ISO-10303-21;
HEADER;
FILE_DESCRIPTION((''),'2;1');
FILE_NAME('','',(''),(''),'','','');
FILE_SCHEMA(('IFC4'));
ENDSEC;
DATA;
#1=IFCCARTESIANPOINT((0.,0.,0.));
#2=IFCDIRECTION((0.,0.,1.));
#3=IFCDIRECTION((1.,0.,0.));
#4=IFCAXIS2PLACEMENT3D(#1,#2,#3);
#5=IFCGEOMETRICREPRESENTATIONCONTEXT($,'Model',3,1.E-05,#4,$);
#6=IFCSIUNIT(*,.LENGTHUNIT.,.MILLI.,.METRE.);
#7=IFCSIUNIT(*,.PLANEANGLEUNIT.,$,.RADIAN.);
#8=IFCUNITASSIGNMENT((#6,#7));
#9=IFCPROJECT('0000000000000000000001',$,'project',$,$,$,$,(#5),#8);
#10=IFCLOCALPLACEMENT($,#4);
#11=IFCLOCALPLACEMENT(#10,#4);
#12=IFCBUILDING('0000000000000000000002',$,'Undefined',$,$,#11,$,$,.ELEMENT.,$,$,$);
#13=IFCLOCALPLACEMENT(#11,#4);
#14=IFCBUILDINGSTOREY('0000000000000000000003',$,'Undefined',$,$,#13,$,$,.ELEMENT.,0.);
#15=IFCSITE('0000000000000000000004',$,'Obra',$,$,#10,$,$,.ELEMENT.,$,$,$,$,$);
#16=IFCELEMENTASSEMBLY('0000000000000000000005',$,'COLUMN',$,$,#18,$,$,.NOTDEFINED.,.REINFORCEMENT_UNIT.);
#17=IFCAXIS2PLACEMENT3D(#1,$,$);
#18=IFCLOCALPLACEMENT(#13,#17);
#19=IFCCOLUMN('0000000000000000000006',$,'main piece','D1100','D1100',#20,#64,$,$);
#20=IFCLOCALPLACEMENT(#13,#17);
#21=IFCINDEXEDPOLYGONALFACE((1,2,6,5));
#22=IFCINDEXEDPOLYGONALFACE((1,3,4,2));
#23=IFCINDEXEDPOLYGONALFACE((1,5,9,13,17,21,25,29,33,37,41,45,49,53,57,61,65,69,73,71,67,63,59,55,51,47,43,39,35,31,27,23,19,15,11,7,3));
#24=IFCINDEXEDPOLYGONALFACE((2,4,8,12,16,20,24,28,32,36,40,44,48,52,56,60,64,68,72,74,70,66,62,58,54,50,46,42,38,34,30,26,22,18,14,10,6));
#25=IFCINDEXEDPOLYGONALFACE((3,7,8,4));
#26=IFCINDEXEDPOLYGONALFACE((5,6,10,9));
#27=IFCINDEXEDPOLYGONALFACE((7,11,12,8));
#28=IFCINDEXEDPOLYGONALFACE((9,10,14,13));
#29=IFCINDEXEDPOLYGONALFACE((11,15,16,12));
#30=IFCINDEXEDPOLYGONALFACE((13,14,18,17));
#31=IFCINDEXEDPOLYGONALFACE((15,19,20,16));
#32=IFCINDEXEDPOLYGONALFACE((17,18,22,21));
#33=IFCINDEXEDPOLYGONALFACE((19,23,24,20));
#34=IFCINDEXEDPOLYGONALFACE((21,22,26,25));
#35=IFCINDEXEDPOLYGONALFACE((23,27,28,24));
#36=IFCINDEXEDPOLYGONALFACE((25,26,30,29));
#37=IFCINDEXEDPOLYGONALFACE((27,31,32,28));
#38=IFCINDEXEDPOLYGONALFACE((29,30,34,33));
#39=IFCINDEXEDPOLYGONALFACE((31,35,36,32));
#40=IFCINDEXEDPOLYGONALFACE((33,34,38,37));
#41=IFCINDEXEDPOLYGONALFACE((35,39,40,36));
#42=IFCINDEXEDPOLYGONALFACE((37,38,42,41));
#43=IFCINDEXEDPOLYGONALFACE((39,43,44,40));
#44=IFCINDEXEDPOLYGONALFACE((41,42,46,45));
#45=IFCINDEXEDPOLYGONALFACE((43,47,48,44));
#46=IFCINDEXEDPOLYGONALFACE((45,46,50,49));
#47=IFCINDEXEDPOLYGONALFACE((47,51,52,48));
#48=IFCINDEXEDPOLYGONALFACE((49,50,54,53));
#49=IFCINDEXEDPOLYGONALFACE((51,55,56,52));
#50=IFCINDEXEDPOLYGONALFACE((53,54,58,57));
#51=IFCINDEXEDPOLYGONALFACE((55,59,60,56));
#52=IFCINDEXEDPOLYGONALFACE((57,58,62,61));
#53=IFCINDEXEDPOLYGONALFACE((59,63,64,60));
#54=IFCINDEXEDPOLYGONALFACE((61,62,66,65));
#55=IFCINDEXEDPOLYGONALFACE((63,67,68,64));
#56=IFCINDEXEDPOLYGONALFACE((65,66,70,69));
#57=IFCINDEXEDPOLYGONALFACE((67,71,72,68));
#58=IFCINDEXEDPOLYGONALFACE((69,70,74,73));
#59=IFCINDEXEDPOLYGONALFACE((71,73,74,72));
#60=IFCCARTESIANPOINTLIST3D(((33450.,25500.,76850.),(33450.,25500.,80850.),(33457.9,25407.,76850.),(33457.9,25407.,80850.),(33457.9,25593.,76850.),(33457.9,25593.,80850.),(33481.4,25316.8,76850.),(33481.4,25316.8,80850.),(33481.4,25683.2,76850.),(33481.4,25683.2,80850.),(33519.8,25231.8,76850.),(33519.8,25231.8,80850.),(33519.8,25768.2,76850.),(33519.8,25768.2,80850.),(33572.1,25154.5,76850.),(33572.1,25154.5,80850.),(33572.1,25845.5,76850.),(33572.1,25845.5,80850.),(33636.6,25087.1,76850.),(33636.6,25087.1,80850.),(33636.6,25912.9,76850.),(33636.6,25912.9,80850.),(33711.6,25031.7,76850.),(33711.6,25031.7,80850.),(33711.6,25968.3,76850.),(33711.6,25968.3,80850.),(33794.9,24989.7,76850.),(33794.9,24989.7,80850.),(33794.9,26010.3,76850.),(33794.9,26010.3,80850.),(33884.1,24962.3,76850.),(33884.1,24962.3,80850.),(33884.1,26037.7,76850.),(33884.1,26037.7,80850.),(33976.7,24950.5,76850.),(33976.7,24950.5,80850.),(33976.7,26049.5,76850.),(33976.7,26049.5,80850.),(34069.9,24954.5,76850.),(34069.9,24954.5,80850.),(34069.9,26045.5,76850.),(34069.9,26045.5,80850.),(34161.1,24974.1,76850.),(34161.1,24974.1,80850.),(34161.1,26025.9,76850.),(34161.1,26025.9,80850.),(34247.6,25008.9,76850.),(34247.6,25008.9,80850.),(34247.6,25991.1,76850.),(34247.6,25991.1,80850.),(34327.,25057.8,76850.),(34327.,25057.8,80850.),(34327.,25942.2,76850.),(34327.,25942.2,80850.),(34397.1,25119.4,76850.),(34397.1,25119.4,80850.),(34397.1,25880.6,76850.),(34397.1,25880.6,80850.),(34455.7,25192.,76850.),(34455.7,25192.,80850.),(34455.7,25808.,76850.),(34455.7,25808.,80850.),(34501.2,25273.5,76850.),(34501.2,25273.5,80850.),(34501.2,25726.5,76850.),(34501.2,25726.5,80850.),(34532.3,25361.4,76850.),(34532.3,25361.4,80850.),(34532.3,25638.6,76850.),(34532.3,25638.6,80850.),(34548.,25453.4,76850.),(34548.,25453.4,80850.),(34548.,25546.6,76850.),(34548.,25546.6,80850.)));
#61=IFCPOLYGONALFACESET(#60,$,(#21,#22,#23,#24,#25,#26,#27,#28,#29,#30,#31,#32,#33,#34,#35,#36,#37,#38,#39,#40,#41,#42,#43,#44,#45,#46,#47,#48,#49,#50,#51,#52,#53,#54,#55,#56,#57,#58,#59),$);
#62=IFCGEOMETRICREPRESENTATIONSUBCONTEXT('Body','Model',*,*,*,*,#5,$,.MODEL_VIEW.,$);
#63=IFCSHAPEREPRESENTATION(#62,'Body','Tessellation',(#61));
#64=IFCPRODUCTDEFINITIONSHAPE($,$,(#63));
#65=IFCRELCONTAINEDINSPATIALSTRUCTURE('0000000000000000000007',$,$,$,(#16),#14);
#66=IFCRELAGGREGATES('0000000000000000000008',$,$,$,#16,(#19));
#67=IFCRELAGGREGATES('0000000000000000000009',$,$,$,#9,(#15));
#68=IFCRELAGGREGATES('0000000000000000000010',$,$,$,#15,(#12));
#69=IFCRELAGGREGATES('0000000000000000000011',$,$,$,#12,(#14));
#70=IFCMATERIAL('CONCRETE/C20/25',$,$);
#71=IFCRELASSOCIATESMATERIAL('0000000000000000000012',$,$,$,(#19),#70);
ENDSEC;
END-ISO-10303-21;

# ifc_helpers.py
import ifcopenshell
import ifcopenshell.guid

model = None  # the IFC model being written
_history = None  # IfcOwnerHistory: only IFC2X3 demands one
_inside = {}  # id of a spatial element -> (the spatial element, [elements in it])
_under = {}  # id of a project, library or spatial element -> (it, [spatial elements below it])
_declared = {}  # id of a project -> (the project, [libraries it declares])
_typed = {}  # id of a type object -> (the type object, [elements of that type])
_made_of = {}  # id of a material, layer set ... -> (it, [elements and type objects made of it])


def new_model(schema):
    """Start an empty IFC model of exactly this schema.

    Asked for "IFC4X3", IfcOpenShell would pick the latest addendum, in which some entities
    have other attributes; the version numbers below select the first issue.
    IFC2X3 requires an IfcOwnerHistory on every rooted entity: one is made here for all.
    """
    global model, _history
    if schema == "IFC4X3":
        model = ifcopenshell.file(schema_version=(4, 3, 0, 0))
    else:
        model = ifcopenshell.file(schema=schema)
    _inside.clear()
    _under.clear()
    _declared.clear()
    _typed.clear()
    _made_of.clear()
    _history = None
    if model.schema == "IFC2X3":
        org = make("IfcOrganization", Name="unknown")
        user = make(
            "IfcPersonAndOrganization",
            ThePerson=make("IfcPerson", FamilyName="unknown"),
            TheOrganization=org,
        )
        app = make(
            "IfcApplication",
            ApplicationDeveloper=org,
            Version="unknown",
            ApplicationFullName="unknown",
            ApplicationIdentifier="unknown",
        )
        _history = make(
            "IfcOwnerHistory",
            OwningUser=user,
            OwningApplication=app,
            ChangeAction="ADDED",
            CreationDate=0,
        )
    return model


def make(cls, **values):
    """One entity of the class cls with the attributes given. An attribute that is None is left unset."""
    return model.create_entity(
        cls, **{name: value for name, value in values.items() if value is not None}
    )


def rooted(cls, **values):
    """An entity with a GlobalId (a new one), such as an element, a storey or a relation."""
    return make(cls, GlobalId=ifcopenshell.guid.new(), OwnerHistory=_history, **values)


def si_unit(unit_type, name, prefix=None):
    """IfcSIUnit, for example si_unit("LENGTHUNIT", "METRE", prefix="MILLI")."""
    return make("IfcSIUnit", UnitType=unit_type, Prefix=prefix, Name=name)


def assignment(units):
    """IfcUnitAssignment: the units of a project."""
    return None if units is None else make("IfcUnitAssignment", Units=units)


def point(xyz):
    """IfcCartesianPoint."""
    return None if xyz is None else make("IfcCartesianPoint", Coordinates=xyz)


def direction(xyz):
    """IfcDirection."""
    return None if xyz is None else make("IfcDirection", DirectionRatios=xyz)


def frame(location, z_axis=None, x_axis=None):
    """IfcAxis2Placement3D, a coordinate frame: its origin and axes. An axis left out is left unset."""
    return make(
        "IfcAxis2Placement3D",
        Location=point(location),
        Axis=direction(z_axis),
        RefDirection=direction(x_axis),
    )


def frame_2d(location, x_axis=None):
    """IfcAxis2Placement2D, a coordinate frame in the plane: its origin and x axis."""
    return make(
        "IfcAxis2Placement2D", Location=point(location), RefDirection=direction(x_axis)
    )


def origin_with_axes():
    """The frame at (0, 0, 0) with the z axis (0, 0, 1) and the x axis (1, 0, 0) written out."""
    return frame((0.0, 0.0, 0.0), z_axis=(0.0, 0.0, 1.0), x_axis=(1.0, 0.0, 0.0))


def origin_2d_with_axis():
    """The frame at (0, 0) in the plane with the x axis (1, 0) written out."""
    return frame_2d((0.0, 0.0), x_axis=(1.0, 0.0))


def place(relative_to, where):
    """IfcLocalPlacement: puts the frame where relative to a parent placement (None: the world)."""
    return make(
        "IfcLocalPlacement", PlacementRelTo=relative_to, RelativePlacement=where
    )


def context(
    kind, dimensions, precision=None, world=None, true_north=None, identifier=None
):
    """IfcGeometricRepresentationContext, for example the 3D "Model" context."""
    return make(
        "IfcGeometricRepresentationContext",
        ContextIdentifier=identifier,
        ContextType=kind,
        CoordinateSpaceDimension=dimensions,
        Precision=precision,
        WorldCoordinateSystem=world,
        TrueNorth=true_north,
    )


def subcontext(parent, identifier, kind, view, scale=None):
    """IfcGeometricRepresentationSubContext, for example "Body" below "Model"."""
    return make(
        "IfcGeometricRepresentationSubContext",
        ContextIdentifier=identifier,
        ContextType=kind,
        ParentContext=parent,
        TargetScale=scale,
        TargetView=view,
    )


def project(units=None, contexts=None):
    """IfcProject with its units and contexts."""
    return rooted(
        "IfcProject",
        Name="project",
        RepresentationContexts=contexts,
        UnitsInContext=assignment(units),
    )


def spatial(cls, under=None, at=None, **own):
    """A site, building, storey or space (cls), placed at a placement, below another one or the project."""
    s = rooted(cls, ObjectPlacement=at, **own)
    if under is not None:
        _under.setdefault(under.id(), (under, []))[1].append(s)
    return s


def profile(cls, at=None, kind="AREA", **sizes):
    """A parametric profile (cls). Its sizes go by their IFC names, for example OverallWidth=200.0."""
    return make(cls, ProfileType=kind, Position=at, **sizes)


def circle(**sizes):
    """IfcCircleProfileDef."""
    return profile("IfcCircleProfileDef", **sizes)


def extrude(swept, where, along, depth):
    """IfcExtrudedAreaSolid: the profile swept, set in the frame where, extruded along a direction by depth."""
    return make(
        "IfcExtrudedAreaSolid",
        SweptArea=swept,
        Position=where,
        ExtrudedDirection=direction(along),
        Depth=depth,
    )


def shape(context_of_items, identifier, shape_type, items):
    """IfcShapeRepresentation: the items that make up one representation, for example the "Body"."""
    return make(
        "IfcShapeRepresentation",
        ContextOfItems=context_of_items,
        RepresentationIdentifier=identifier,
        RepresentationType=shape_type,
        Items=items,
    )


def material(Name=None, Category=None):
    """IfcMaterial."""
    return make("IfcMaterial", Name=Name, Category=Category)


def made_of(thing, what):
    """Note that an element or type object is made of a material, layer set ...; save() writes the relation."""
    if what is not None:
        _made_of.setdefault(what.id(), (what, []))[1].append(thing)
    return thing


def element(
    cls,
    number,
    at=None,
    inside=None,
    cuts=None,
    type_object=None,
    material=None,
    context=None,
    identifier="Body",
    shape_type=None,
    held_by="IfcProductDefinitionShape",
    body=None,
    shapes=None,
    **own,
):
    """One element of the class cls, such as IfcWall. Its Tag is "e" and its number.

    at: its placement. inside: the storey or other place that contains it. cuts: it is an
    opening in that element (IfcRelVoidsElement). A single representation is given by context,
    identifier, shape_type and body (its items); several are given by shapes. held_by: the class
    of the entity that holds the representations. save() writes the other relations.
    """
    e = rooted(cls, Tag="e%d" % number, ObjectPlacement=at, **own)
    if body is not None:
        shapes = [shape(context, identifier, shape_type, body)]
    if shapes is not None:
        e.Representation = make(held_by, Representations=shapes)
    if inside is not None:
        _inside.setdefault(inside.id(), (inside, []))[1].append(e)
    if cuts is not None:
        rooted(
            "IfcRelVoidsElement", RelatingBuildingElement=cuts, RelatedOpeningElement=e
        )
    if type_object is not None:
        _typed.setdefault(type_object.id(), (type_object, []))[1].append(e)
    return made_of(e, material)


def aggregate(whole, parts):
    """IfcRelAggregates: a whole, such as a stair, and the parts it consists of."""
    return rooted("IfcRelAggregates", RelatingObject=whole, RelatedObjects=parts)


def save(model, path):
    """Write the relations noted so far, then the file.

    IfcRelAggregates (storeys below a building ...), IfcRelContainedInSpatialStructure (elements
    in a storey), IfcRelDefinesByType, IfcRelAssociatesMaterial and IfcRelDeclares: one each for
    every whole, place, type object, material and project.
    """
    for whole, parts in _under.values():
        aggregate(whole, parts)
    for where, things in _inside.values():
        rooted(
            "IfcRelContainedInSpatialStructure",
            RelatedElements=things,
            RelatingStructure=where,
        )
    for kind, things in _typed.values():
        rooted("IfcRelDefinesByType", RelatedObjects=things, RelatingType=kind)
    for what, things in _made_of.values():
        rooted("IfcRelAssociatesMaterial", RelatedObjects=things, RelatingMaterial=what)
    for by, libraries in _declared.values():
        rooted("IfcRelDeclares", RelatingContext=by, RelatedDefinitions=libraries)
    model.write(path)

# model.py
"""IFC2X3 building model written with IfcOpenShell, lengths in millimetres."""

from ifc_helpers import new_model, si_unit, frame, origin_with_axes, origin_2d_with_axis, place, context, subcontext, project, spatial, circle, extrude, material, element, aggregate, save


model = new_model("IFC2X3")

# Units and contexts
model_context = context("Model", 3, precision=1e-05, world=origin_with_axes())
body_context = subcontext(model_context, "Body", "Model", "MODEL_VIEW")
ifc_project = project(units=[si_unit("LENGTHUNIT", "METRE", prefix="MILLI"), si_unit("PLANEANGLEUNIT", "RADIAN")], contexts=[model_context])

# Site, building, storey
site_placement = place(None, origin_with_axes())
site = spatial("IfcSite", under=ifc_project, at=site_placement, Name="Obra", CompositionType="ELEMENT")
building_placement = place(site_placement, origin_with_axes())
building = spatial("IfcBuilding", under=site, at=building_placement, Name="Undefined", CompositionType="ELEMENT")
storey_placement = place(building_placement, origin_with_axes())
storey = spatial("IfcBuildingStorey", under=building, at=storey_placement, Name="Undefined", CompositionType="ELEMENT", Elevation=0.0)

# Element assembly, column
assembly_1_placement = place(storey_placement, origin_with_axes())
assembly_1 = element("IfcElementAssembly", 1, at=assembly_1_placement, inside=storey, Name="COLUMN", AssemblyPlace="NOTDEFINED", PredefinedType="REINFORCEMENT_UNIT")
ifc_material_1 = material(Name="CONCRETE/C20/25")
column_placement = place(assembly_1_placement, frame((34000.0, 25500.0, 76850.0), z_axis=(0.0, 0.0, 1.0), x_axis=(0.0, 1.0, 0.0)))
column = element("IfcColumn", 2, at=column_placement, material=ifc_material_1, Name="main piece", Description="D1100", ObjectType="D1100", context=body_context, shape_type="SweptSolid", body=[
    extrude(circle(Radius=550.0, at=origin_2d_with_axis()), frame((0.0, 0.0, 4000.0), z_axis=(0.0, 0.0, -1.0), x_axis=(0.0, 1.0, 0.0)), (0.0, 0.0, 1.0), 4000.0),
])
aggregate(assembly_1, [column])

save(model, "model.ifc")
